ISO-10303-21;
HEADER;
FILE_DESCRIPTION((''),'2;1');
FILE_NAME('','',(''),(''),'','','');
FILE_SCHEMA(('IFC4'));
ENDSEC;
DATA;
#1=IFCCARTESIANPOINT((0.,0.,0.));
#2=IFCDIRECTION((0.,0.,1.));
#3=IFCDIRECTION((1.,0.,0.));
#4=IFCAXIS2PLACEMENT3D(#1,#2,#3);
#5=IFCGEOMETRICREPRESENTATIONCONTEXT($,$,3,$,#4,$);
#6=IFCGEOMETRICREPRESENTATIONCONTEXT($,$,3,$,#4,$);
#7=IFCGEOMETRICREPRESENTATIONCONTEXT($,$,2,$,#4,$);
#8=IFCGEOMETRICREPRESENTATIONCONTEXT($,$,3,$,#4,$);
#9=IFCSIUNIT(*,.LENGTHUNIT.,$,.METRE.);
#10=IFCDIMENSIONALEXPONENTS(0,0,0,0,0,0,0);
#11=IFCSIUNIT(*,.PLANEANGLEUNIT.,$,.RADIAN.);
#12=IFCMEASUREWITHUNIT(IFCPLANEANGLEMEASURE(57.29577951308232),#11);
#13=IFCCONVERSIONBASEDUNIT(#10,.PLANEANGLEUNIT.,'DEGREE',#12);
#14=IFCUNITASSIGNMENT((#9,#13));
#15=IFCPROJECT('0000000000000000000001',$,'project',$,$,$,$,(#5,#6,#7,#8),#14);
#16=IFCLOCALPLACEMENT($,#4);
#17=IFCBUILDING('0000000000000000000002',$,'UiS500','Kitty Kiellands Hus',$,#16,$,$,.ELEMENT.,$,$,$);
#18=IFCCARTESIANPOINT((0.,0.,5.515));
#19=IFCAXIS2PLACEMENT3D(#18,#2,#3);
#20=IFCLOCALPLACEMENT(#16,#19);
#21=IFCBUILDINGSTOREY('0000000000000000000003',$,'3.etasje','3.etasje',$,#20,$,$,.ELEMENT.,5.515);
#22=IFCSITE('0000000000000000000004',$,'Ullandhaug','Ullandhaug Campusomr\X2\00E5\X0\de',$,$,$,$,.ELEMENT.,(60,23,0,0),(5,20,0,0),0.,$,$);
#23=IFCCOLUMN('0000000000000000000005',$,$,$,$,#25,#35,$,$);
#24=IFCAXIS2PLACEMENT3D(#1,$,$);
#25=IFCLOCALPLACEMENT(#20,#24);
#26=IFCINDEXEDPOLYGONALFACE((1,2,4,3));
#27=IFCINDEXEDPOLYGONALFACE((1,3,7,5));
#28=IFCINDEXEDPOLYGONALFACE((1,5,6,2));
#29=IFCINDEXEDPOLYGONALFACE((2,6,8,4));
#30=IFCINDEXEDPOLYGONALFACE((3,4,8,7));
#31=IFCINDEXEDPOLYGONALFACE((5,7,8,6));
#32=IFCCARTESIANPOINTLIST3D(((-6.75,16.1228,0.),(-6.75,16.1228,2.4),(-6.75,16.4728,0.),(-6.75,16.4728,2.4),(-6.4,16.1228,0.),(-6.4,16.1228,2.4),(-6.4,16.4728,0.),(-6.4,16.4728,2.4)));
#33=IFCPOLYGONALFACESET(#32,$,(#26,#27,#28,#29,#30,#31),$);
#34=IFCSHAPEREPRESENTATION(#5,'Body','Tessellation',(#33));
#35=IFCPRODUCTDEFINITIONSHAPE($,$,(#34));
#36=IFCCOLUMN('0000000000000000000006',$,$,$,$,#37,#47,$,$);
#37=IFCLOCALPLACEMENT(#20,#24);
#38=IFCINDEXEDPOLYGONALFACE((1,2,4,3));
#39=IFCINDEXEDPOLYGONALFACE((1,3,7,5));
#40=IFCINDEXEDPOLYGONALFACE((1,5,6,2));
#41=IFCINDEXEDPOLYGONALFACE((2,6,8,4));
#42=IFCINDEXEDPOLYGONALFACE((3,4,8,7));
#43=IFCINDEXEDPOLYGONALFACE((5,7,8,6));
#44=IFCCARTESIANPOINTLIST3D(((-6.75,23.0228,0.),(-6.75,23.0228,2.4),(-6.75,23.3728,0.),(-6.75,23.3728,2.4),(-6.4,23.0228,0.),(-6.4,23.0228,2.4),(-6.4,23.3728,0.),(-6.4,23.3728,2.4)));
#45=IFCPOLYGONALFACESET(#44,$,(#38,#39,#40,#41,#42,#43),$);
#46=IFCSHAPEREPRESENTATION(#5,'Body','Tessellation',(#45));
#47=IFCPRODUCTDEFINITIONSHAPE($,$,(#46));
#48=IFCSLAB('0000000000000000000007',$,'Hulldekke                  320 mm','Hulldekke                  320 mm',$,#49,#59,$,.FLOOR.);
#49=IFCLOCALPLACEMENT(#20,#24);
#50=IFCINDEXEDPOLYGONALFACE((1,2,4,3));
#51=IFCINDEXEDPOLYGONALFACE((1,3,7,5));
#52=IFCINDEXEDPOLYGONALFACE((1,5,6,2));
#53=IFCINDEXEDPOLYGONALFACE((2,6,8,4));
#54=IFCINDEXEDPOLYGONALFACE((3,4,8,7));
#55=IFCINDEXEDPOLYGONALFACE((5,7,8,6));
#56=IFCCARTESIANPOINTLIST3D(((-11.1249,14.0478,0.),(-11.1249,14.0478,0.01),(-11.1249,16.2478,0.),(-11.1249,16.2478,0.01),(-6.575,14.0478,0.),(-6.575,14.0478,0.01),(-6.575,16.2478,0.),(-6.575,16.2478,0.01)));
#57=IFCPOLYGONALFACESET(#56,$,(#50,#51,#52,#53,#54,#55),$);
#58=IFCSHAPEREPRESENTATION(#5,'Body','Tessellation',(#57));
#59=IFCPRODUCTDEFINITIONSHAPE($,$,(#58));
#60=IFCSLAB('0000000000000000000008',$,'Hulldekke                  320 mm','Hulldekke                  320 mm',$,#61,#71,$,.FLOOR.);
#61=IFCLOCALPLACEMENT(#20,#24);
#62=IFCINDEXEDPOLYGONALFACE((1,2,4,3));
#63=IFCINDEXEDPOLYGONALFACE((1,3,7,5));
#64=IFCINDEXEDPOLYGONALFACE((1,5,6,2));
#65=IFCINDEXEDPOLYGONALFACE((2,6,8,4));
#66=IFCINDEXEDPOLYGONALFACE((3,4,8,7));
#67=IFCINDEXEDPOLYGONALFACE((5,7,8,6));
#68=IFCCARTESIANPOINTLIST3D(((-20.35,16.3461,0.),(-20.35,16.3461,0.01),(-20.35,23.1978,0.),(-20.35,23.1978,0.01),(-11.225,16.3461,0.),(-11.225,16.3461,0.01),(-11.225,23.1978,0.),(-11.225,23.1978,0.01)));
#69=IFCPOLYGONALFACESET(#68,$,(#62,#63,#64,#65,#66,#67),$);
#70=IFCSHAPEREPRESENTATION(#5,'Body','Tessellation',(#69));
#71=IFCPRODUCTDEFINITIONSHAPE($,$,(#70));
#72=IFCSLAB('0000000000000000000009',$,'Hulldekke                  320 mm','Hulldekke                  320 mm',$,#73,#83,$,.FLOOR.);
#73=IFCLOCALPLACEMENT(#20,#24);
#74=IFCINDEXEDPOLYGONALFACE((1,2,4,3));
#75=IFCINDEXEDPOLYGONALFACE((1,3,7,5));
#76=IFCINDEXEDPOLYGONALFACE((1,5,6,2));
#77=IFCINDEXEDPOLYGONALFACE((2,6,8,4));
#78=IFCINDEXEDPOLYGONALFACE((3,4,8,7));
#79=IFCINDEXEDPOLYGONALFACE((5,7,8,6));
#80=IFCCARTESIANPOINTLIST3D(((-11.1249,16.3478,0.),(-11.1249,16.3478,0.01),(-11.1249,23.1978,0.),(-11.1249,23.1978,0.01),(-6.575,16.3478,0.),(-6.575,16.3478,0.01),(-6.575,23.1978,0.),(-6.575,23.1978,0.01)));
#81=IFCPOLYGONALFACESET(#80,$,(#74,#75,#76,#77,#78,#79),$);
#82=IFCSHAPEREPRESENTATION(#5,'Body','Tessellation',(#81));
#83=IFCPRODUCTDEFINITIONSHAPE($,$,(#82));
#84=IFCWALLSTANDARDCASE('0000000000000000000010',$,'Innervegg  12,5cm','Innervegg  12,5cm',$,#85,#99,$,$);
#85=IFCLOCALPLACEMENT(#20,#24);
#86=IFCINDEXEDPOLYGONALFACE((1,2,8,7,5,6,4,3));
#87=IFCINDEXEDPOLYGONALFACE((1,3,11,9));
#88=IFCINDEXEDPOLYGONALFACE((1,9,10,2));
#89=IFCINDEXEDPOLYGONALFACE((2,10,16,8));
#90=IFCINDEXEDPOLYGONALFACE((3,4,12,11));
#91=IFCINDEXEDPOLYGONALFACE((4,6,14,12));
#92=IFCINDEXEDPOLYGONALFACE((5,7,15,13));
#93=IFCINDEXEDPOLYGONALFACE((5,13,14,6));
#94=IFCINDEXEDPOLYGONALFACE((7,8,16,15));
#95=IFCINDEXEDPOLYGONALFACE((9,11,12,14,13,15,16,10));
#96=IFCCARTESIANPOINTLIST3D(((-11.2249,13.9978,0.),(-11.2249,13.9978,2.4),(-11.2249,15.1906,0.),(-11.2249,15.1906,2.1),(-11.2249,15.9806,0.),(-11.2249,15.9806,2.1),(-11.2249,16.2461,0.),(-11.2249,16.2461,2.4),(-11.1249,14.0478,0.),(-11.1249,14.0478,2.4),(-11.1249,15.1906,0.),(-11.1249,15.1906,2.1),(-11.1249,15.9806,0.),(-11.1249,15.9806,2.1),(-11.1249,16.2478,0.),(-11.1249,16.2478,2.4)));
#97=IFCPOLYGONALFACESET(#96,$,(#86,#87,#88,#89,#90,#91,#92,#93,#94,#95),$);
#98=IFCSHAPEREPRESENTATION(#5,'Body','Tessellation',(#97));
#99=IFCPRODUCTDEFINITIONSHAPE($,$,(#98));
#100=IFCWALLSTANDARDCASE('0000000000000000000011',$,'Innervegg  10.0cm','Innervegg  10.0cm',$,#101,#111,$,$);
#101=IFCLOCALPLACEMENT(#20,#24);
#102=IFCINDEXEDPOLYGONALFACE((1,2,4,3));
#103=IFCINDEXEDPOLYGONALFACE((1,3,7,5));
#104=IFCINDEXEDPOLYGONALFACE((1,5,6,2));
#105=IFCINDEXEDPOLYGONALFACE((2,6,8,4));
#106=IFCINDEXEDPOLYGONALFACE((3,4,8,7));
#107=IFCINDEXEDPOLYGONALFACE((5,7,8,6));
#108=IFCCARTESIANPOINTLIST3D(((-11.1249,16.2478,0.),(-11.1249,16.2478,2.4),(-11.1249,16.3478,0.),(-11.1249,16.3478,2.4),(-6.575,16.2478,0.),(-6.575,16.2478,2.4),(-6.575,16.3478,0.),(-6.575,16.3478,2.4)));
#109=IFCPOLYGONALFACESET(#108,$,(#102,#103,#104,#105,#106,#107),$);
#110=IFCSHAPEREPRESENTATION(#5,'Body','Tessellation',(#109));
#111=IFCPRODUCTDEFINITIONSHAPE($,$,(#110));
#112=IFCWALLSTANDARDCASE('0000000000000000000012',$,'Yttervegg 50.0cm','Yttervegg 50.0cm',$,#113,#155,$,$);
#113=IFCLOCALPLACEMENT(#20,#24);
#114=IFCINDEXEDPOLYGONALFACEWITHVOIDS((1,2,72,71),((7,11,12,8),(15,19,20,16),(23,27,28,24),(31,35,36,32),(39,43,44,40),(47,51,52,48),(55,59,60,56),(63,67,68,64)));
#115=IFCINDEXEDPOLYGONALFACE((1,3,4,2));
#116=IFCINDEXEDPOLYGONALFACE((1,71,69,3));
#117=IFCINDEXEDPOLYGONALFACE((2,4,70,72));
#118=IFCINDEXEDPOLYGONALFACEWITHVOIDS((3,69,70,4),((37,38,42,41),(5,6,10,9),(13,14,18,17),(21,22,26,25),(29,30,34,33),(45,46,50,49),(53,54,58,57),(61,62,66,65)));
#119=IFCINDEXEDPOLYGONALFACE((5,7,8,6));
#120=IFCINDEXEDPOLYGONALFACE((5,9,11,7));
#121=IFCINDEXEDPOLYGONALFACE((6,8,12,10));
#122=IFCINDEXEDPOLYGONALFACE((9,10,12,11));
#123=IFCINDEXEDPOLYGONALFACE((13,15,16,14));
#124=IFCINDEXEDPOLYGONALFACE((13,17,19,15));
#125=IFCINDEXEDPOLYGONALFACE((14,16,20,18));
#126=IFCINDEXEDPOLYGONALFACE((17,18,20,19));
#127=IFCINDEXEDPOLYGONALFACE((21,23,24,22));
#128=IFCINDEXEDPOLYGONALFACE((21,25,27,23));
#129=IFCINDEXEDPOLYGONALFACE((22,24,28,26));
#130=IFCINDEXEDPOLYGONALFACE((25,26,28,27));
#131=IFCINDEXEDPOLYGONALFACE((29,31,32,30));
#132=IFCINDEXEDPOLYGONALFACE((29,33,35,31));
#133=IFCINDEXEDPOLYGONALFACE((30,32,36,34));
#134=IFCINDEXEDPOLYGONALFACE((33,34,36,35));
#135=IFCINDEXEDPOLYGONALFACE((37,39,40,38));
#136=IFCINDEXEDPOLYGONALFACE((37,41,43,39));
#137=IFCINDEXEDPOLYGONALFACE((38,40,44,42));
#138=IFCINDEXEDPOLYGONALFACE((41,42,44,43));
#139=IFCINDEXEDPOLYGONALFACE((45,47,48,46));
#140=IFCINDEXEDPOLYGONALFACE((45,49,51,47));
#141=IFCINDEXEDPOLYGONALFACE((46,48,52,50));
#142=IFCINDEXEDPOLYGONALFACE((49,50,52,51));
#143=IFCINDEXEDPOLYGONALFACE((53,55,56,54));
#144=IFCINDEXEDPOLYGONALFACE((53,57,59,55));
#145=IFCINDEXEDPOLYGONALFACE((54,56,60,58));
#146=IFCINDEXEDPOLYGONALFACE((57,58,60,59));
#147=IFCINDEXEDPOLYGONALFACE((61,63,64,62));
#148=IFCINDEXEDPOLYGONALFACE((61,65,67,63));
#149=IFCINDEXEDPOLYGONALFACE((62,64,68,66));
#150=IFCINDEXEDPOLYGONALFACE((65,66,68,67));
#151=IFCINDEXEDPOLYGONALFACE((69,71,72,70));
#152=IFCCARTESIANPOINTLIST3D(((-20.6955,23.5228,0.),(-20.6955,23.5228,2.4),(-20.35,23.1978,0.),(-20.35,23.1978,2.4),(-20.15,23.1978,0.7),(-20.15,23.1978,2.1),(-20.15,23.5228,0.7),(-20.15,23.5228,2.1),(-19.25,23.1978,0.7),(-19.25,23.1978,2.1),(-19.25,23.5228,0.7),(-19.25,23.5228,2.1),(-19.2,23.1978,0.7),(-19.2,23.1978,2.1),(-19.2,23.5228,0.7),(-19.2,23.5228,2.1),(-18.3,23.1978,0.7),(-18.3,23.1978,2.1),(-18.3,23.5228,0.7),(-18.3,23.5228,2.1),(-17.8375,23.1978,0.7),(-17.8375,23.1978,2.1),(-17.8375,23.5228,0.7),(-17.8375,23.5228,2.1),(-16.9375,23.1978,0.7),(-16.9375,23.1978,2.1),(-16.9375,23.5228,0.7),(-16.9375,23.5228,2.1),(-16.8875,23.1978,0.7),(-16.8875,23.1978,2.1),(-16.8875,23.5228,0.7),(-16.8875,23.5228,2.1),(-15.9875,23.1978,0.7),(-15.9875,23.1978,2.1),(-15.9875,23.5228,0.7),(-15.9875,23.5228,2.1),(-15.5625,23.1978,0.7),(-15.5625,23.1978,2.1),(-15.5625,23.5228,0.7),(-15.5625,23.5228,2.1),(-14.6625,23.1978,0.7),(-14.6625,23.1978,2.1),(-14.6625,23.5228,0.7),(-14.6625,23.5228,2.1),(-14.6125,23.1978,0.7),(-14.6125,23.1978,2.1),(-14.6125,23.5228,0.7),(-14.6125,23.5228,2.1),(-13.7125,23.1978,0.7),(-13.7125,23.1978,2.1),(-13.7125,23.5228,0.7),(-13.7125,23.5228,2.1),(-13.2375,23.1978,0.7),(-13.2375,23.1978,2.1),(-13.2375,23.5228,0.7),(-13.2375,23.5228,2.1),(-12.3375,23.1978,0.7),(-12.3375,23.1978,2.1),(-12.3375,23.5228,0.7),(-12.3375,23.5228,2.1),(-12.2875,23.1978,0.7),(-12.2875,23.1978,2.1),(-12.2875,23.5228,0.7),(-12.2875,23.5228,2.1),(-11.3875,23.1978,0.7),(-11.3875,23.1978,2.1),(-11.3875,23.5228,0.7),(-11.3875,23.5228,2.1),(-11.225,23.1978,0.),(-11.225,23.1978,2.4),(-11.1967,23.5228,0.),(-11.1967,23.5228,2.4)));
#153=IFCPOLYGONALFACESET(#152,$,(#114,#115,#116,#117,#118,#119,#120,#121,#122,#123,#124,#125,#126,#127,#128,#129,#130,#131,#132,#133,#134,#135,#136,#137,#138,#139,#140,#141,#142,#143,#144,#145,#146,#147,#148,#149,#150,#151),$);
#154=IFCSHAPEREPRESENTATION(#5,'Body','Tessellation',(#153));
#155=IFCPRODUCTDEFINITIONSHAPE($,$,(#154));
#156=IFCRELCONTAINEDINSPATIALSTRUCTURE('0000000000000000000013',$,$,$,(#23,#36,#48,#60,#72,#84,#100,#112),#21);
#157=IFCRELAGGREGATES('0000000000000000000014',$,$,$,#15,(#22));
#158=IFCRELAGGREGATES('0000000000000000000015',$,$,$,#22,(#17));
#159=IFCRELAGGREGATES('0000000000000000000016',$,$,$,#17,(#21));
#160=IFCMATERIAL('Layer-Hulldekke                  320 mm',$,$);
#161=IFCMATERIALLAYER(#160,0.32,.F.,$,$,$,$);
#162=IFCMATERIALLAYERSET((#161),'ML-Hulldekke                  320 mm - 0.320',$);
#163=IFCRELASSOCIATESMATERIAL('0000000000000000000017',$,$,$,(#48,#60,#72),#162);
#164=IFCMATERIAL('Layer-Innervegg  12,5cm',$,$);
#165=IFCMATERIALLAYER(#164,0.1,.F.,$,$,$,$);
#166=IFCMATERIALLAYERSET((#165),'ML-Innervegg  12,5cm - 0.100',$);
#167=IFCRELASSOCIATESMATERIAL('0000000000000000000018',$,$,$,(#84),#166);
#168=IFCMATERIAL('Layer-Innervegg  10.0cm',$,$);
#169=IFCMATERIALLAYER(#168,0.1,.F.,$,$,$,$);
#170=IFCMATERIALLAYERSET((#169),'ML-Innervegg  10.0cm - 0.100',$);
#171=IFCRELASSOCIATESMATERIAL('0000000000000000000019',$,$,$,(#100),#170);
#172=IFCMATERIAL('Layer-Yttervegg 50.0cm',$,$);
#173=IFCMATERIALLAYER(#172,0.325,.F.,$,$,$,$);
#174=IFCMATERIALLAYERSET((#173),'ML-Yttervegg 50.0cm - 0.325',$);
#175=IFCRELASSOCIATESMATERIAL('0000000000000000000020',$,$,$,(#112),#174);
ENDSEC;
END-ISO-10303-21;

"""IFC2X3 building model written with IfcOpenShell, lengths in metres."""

from ifc_helpers import new_model, entity, si_unit, converted_unit, frame, origin_with_axes, origin_2d_with_axis, place, context, project, spatial, polyline, rectangle, outline, extrude, material, layer, layer_set, layer_usage, element, save


model = new_model("IFC2X3")

# Units and contexts
context_of_model_1 = context(None, 3, world=origin_with_axes())
context_of_model_2 = context(None, 3, world=origin_with_axes())
context_of_model_3 = context(None, 2, world=origin_with_axes())
context_of_model_4 = context(None, 3, world=origin_with_axes())
ifc_project = project(units=[si_unit("LENGTHUNIT", "METRE"), converted_unit("PLANEANGLEUNIT", "DEGREE", entity("IfcPlaneAngleMeasure", 57.29577951308232), si_unit("PLANEANGLEUNIT", "RADIAN"), dimensions=[0, 0, 0, 0, 0, 0, 0])], contexts=[context_of_model_1, context_of_model_2, context_of_model_3, context_of_model_4])

# Site, building, storey
site = spatial("IfcSite", under=ifc_project, Name="Ullandhaug", Description="Ullandhaug Campusområde", CompositionType="ELEMENT", RefLatitude=(60, 23, 0, 0), RefLongitude=(5, 20, 0, 0), RefElevation=0.0)
building_placement = place(None, origin_with_axes())
building = spatial("IfcBuilding", under=site, at=building_placement, Name="UiS500", Description="Kitty Kiellands Hus", CompositionType="ELEMENT")
storey_placement = place(building_placement, frame((0.0, 0.0, 5.515), z_axis=(0.0, 0.0, 1.0), x_axis=(1.0, 0.0, 0.0)))
storey = spatial("IfcBuildingStorey", under=building, at=storey_placement, Name="3.etasje", Description="3.etasje", CompositionType="ELEMENT", Elevation=5.515)

# Columns
for number, where, z_axis, x_axis in (
    (1, (-6.575, 16.2978, 0.0), (0.0, 0.0, 1.0), (1.0, 0.0, 0.0)),
    (2, (-6.575, 23.1978, 0.0), (0.0, 0.0, 1.0), (1.0, 0.0, 0.0)),
):
    element("IfcColumn", number, at=place(storey_placement, frame(where, z_axis=z_axis, x_axis=x_axis)), inside=storey, context=context_of_model_1, shape_type="SweptSolid", body=[
        extrude(rectangle(XDim=0.35, YDim=0.35, at=origin_2d_with_axis()), origin_with_axes(), (0.0, 0.0, 1.0), 2.4),
    ])

# Slabs
ifc_material_1 = material(Name="Layer-Hulldekke                  320 mm")
ifc_layer_1 = layer(ifc_material_1, 0.32, ventilated=False)
ifc_layer_set_1 = layer_set([ifc_layer_1], Name="ML-Hulldekke                  320 mm - 0.320")
ifc_layer_usage_1 = layer_usage(ifc_layer_set_1, "AXIS2", "POSITIVE", 0.0)
slab_1_placement = place(storey_placement, frame((-11.1249, 16.2478, 0.0), z_axis=(0.0, 0.0, 1.0), x_axis=(1.0, 0.0, 0.0)))
element("IfcSlab", 3, at=slab_1_placement, inside=storey, material=ifc_layer_usage_1, Name="Hulldekke                  320 mm", Description="Hulldekke                  320 mm", PredefinedType="FLOOR", context=context_of_model_1, shape_type="SweptSolid", body=[
    extrude(outline(polyline([(0.0, 0.0), (2.2, 0.0), (2.2, 4.5499), (0.0, 4.5499), (0.0, 0.0)])), frame((0.0, 0.0, 0.0), z_axis=(0.0, 0.0, 1.0), x_axis=(0.0, -1.0, 0.0)), (0.0, 0.0, 1.0), 0.01),
])
slab_2_placement = place(storey_placement, frame((-11.225, 23.1978, 0.0), z_axis=(0.0, 0.0, 1.0), x_axis=(1.0, 0.0, 0.0)))
element("IfcSlab", 4, at=slab_2_placement, inside=storey, material=ifc_layer_usage_1, Name="Hulldekke                  320 mm", Description="Hulldekke                  320 mm", PredefinedType="FLOOR", context=context_of_model_1, shape_type="SweptSolid", body=[
    extrude(outline(polyline([(0.0, 0.0), (9.125, 0.0), (9.125, 6.8517), (0.0, 6.8517), (0.0, 0.0)])), frame((0.0, 0.0, 0.0), z_axis=(0.0, 0.0, 1.0), x_axis=(-1.0, 0.0, 0.0)), (0.0, 0.0, 1.0), 0.01),
])
slab_3_placement = place(storey_placement, frame((-6.575, 23.1978, 0.0), z_axis=(0.0, 0.0, 1.0), x_axis=(1.0, 0.0, 0.0)))
element("IfcSlab", 5, at=slab_3_placement, inside=storey, material=ifc_layer_usage_1, Name="Hulldekke                  320 mm", Description="Hulldekke                  320 mm", PredefinedType="FLOOR", context=context_of_model_1, shape_type="SweptSolid", body=[
    extrude(outline(polyline([(0.0, 0.0), (4.5499, 0.0), (4.5499, 6.85), (0.0, 6.85), (0.0, 0.0)])), frame((0.0, 0.0, 0.0), z_axis=(0.0, 0.0, 1.0), x_axis=(-1.0, 0.0, 0.0)), (0.0, 0.0, 1.0), 0.01),
])

# Wall, opening
ifc_material_2 = material(Name="Layer-Innervegg  12,5cm")
ifc_layer_2 = layer(ifc_material_2, 0.1, ventilated=False)
ifc_layer_set_2 = layer_set([ifc_layer_2], Name="ML-Innervegg  12,5cm - 0.100")
ifc_layer_usage_2 = layer_usage(ifc_layer_set_2, "AXIS2", "POSITIVE", 0.0)
wall_1_placement = place(storey_placement, frame((-11.2249, 16.2461, 0.0), z_axis=(0.0, 0.0, 1.0), x_axis=(-0.000009, -1.0, 0.0)))
wall_1 = element("IfcWallStandardCase", 6, at=wall_1_placement, inside=storey, material=ifc_layer_usage_2, Name="Innervegg  12,5cm", Description="Innervegg  12,5cm", context=context_of_model_1, shape_type="SweptSolid", body=[
    extrude(outline(polyline([(0.0, 0.0), (2.2483, 0.0), (2.1983, 0.1), (-0.0017, 0.1), (0.0, 0.0)])), frame((0.0, 0.0, 0.0), z_axis=(0.0, 0.0, 1.0), x_axis=(1.0, 0.0, 0.0)), (0.0, 0.0, 1.0), 2.4),
])
opening_1_placement = place(wall_1_placement, frame((0.2655, 0.1, 0.0), z_axis=(0.0, 0.0, 1.0), x_axis=(1.0, 0.0, 0.0)))
element("IfcOpeningElement", 7, at=opening_1_placement, cuts=wall_1, context=context_of_model_1, shape_type="SweptSolid", body=[
    extrude(outline(polyline([(0.0, 0.0), (2.1, 0.0), (2.1, 0.79), (0.0, 0.79), (0.0, 0.0)])), frame((0.0, 0.0, 0.0), z_axis=(-0.000009, 1.0, 0.0), x_axis=(0.0, 0.0, 1.0)), (0.0, -0.000009, -1.0), 0.1),
])

# Wall
ifc_material_3 = material(Name="Layer-Innervegg  10.0cm")
ifc_layer_3 = layer(ifc_material_3, 0.1, ventilated=False)
ifc_layer_set_3 = layer_set([ifc_layer_3], Name="ML-Innervegg  10.0cm - 0.100")
ifc_layer_usage_3 = layer_usage(ifc_layer_set_3, "AXIS2", "POSITIVE", 0.0)
wall_2_placement = place(storey_placement, frame((-6.575, 16.3478, 0.0), z_axis=(0.0, 0.0, 1.0), x_axis=(-1.0, 0.0, 0.0)))
element("IfcWallStandardCase", 8, at=wall_2_placement, inside=storey, material=ifc_layer_usage_3, Name="Innervegg  10.0cm", Description="Innervegg  10.0cm", context=context_of_model_1, shape_type="SweptSolid", body=[
    extrude(outline(polyline([(0.0, 0.0), (4.5499, 0.0), (4.5499, 0.1), (0.0, 0.1), (0.0, 0.0)])), frame((0.0, 0.0, 0.0), z_axis=(0.0, 0.0, 1.0), x_axis=(1.0, 0.0, 0.0)), (0.0, 0.0, 1.0), 2.4),
])

# Wall, openings
ifc_material_4 = material(Name="Layer-Yttervegg 50.0cm")
ifc_layer_4 = layer(ifc_material_4, 0.325, ventilated=False)
ifc_layer_set_4 = layer_set([ifc_layer_4], Name="ML-Yttervegg 50.0cm - 0.325")
ifc_layer_usage_4 = layer_usage(ifc_layer_set_4, "AXIS2", "POSITIVE", 0.0)
wall_3_placement = place(storey_placement, frame((-11.1967, 23.5228, 0.0), z_axis=(0.0, 0.0, 1.0), x_axis=(-1.0, 0.0, 0.0)))
wall_3 = element("IfcWallStandardCase", 9, at=wall_3_placement, inside=storey, material=ifc_layer_usage_4, Name="Yttervegg 50.0cm", Description="Yttervegg 50.0cm", context=context_of_model_1, shape_type="SweptSolid", body=[
    extrude(outline(polyline([(0.0, 0.0), (9.4987, 0.0), (9.1533, 0.325), (0.0283, 0.325), (0.0, 0.0)])), frame((0.0, 0.0, 0.0), z_axis=(0.0, 0.0, 1.0), x_axis=(1.0, 0.0, 0.0)), (0.0, 0.0, 1.0), 2.4),
])
opening_2_placement = place(wall_3_placement, frame((0.1908, 0.325, 0.7), z_axis=(0.0, 0.0, 1.0), x_axis=(1.0, 0.0, 0.0)))
element("IfcOpeningElement", 10, at=opening_2_placement, cuts=wall_3, context=context_of_model_1, shape_type="SweptSolid", body=[
    extrude(outline(polyline([(0.0, 0.0), (1.4, 0.0), (1.4, 0.9), (0.0, 0.9), (0.0, 0.0)])), frame((0.0, 0.0, 0.0), z_axis=(0.0, 1.0, 0.0), x_axis=(0.0, 0.0, 1.0)), (0.0, 0.0, -1.0), 0.325),
])
opening_3_placement = place(wall_3_placement, frame((1.1408, 0.325, 0.7), z_axis=(0.0, 0.0, 1.0), x_axis=(1.0, 0.0, 0.0)))
element("IfcOpeningElement", 11, at=opening_3_placement, cuts=wall_3, context=context_of_model_1, shape_type="SweptSolid", body=[
    extrude(outline(polyline([(0.0, 0.0), (1.4, 0.0), (1.4, 0.9), (0.0, 0.9), (0.0, 0.0)])), frame((0.0, 0.0, 0.0), z_axis=(0.0, 1.0, 0.0), x_axis=(0.0, 0.0, 1.0)), (0.0, 0.0, -1.0), 0.325),
])
opening_4_placement = place(wall_3_placement, frame((2.5158, 0.325, 0.7), z_axis=(0.0, 0.0, 1.0), x_axis=(1.0, 0.0, 0.0)))
element("IfcOpeningElement", 12, at=opening_4_placement, cuts=wall_3, context=context_of_model_1, shape_type="SweptSolid", body=[
    extrude(outline(polyline([(0.0, 0.0), (1.4, 0.0), (1.4, 0.9), (0.0, 0.9), (0.0, 0.0)])), frame((0.0, 0.0, 0.0), z_axis=(0.0, 1.0, 0.0), x_axis=(0.0, 0.0, 1.0)), (0.0, 0.0, -1.0), 0.325),
])
opening_5_placement = place(wall_3_placement, frame((3.4658, 0.325, 0.7), z_axis=(0.0, 0.0, 1.0), x_axis=(1.0, 0.0, 0.0)))
element("IfcOpeningElement", 13, at=opening_5_placement, cuts=wall_3, context=context_of_model_1, shape_type="SweptSolid", body=[
    extrude(outline(polyline([(0.0, 0.0), (1.4, 0.0), (1.4, 0.9), (0.0, 0.9), (0.0, 0.0)])), frame((0.0, 0.0, 0.0), z_axis=(0.0, 1.0, 0.0), x_axis=(0.0, 0.0, 1.0)), (0.0, 0.0, -1.0), 0.325),
])
opening_6_placement = place(wall_3_placement, frame((4.7908, 0.325, 0.7), z_axis=(0.0, 0.0, 1.0), x_axis=(1.0, 0.0, 0.0)))
element("IfcOpeningElement", 14, at=opening_6_placement, cuts=wall_3, context=context_of_model_1, shape_type="SweptSolid", body=[
    extrude(outline(polyline([(0.0, 0.0), (1.4, 0.0), (1.4, 0.9), (0.0, 0.9), (0.0, 0.0)])), frame((0.0, 0.0, 0.0), z_axis=(0.0, 1.0, 0.0), x_axis=(0.0, 0.0, 1.0)), (0.0, 0.0, -1.0), 0.325),
])
opening_7_placement = place(wall_3_placement, frame((5.7408, 0.325, 0.7), z_axis=(0.0, 0.0, 1.0), x_axis=(1.0, 0.0, 0.0)))
element("IfcOpeningElement", 15, at=opening_7_placement, cuts=wall_3, context=context_of_model_1, shape_type="SweptSolid", body=[
    extrude(outline(polyline([(0.0, 0.0), (1.4, 0.0), (1.4, 0.9), (0.0, 0.9), (0.0, 0.0)])), frame((0.0, 0.0, 0.0), z_axis=(0.0, 1.0, 0.0), x_axis=(0.0, 0.0, 1.0)), (0.0, 0.0, -1.0), 0.325),
])
opening_8_placement = place(wall_3_placement, frame((7.1033, 0.325, 0.7), z_axis=(0.0, 0.0, 1.0), x_axis=(1.0, 0.0, 0.0)))
element("IfcOpeningElement", 16, at=opening_8_placement, cuts=wall_3, context=context_of_model_1, shape_type="SweptSolid", body=[
    extrude(outline(polyline([(0.0, 0.0), (1.4, 0.0), (1.4, 0.9), (0.0, 0.9), (0.0, 0.0)])), frame((0.0, 0.0, 0.0), z_axis=(0.0, 1.0, 0.0), x_axis=(0.0, 0.0, 1.0)), (0.0, 0.0, -1.0), 0.325),
])
opening_9_placement = place(wall_3_placement, frame((8.0533, 0.325, 0.7), z_axis=(0.0, 0.0, 1.0), x_axis=(1.0, 0.0, 0.0)))
element("IfcOpeningElement", 17, at=opening_9_placement, cuts=wall_3, context=context_of_model_1, shape_type="SweptSolid", body=[
    extrude(outline(polyline([(0.0, 0.0), (1.4, 0.0), (1.4, 0.9), (0.0, 0.9), (0.0, 0.0)])), frame((0.0, 0.0, 0.0), z_axis=(0.0, 1.0, 0.0), x_axis=(0.0, 0.0, 1.0)), (0.0, 0.0, -1.0), 0.325),
])

save(model, "model.ifc")
